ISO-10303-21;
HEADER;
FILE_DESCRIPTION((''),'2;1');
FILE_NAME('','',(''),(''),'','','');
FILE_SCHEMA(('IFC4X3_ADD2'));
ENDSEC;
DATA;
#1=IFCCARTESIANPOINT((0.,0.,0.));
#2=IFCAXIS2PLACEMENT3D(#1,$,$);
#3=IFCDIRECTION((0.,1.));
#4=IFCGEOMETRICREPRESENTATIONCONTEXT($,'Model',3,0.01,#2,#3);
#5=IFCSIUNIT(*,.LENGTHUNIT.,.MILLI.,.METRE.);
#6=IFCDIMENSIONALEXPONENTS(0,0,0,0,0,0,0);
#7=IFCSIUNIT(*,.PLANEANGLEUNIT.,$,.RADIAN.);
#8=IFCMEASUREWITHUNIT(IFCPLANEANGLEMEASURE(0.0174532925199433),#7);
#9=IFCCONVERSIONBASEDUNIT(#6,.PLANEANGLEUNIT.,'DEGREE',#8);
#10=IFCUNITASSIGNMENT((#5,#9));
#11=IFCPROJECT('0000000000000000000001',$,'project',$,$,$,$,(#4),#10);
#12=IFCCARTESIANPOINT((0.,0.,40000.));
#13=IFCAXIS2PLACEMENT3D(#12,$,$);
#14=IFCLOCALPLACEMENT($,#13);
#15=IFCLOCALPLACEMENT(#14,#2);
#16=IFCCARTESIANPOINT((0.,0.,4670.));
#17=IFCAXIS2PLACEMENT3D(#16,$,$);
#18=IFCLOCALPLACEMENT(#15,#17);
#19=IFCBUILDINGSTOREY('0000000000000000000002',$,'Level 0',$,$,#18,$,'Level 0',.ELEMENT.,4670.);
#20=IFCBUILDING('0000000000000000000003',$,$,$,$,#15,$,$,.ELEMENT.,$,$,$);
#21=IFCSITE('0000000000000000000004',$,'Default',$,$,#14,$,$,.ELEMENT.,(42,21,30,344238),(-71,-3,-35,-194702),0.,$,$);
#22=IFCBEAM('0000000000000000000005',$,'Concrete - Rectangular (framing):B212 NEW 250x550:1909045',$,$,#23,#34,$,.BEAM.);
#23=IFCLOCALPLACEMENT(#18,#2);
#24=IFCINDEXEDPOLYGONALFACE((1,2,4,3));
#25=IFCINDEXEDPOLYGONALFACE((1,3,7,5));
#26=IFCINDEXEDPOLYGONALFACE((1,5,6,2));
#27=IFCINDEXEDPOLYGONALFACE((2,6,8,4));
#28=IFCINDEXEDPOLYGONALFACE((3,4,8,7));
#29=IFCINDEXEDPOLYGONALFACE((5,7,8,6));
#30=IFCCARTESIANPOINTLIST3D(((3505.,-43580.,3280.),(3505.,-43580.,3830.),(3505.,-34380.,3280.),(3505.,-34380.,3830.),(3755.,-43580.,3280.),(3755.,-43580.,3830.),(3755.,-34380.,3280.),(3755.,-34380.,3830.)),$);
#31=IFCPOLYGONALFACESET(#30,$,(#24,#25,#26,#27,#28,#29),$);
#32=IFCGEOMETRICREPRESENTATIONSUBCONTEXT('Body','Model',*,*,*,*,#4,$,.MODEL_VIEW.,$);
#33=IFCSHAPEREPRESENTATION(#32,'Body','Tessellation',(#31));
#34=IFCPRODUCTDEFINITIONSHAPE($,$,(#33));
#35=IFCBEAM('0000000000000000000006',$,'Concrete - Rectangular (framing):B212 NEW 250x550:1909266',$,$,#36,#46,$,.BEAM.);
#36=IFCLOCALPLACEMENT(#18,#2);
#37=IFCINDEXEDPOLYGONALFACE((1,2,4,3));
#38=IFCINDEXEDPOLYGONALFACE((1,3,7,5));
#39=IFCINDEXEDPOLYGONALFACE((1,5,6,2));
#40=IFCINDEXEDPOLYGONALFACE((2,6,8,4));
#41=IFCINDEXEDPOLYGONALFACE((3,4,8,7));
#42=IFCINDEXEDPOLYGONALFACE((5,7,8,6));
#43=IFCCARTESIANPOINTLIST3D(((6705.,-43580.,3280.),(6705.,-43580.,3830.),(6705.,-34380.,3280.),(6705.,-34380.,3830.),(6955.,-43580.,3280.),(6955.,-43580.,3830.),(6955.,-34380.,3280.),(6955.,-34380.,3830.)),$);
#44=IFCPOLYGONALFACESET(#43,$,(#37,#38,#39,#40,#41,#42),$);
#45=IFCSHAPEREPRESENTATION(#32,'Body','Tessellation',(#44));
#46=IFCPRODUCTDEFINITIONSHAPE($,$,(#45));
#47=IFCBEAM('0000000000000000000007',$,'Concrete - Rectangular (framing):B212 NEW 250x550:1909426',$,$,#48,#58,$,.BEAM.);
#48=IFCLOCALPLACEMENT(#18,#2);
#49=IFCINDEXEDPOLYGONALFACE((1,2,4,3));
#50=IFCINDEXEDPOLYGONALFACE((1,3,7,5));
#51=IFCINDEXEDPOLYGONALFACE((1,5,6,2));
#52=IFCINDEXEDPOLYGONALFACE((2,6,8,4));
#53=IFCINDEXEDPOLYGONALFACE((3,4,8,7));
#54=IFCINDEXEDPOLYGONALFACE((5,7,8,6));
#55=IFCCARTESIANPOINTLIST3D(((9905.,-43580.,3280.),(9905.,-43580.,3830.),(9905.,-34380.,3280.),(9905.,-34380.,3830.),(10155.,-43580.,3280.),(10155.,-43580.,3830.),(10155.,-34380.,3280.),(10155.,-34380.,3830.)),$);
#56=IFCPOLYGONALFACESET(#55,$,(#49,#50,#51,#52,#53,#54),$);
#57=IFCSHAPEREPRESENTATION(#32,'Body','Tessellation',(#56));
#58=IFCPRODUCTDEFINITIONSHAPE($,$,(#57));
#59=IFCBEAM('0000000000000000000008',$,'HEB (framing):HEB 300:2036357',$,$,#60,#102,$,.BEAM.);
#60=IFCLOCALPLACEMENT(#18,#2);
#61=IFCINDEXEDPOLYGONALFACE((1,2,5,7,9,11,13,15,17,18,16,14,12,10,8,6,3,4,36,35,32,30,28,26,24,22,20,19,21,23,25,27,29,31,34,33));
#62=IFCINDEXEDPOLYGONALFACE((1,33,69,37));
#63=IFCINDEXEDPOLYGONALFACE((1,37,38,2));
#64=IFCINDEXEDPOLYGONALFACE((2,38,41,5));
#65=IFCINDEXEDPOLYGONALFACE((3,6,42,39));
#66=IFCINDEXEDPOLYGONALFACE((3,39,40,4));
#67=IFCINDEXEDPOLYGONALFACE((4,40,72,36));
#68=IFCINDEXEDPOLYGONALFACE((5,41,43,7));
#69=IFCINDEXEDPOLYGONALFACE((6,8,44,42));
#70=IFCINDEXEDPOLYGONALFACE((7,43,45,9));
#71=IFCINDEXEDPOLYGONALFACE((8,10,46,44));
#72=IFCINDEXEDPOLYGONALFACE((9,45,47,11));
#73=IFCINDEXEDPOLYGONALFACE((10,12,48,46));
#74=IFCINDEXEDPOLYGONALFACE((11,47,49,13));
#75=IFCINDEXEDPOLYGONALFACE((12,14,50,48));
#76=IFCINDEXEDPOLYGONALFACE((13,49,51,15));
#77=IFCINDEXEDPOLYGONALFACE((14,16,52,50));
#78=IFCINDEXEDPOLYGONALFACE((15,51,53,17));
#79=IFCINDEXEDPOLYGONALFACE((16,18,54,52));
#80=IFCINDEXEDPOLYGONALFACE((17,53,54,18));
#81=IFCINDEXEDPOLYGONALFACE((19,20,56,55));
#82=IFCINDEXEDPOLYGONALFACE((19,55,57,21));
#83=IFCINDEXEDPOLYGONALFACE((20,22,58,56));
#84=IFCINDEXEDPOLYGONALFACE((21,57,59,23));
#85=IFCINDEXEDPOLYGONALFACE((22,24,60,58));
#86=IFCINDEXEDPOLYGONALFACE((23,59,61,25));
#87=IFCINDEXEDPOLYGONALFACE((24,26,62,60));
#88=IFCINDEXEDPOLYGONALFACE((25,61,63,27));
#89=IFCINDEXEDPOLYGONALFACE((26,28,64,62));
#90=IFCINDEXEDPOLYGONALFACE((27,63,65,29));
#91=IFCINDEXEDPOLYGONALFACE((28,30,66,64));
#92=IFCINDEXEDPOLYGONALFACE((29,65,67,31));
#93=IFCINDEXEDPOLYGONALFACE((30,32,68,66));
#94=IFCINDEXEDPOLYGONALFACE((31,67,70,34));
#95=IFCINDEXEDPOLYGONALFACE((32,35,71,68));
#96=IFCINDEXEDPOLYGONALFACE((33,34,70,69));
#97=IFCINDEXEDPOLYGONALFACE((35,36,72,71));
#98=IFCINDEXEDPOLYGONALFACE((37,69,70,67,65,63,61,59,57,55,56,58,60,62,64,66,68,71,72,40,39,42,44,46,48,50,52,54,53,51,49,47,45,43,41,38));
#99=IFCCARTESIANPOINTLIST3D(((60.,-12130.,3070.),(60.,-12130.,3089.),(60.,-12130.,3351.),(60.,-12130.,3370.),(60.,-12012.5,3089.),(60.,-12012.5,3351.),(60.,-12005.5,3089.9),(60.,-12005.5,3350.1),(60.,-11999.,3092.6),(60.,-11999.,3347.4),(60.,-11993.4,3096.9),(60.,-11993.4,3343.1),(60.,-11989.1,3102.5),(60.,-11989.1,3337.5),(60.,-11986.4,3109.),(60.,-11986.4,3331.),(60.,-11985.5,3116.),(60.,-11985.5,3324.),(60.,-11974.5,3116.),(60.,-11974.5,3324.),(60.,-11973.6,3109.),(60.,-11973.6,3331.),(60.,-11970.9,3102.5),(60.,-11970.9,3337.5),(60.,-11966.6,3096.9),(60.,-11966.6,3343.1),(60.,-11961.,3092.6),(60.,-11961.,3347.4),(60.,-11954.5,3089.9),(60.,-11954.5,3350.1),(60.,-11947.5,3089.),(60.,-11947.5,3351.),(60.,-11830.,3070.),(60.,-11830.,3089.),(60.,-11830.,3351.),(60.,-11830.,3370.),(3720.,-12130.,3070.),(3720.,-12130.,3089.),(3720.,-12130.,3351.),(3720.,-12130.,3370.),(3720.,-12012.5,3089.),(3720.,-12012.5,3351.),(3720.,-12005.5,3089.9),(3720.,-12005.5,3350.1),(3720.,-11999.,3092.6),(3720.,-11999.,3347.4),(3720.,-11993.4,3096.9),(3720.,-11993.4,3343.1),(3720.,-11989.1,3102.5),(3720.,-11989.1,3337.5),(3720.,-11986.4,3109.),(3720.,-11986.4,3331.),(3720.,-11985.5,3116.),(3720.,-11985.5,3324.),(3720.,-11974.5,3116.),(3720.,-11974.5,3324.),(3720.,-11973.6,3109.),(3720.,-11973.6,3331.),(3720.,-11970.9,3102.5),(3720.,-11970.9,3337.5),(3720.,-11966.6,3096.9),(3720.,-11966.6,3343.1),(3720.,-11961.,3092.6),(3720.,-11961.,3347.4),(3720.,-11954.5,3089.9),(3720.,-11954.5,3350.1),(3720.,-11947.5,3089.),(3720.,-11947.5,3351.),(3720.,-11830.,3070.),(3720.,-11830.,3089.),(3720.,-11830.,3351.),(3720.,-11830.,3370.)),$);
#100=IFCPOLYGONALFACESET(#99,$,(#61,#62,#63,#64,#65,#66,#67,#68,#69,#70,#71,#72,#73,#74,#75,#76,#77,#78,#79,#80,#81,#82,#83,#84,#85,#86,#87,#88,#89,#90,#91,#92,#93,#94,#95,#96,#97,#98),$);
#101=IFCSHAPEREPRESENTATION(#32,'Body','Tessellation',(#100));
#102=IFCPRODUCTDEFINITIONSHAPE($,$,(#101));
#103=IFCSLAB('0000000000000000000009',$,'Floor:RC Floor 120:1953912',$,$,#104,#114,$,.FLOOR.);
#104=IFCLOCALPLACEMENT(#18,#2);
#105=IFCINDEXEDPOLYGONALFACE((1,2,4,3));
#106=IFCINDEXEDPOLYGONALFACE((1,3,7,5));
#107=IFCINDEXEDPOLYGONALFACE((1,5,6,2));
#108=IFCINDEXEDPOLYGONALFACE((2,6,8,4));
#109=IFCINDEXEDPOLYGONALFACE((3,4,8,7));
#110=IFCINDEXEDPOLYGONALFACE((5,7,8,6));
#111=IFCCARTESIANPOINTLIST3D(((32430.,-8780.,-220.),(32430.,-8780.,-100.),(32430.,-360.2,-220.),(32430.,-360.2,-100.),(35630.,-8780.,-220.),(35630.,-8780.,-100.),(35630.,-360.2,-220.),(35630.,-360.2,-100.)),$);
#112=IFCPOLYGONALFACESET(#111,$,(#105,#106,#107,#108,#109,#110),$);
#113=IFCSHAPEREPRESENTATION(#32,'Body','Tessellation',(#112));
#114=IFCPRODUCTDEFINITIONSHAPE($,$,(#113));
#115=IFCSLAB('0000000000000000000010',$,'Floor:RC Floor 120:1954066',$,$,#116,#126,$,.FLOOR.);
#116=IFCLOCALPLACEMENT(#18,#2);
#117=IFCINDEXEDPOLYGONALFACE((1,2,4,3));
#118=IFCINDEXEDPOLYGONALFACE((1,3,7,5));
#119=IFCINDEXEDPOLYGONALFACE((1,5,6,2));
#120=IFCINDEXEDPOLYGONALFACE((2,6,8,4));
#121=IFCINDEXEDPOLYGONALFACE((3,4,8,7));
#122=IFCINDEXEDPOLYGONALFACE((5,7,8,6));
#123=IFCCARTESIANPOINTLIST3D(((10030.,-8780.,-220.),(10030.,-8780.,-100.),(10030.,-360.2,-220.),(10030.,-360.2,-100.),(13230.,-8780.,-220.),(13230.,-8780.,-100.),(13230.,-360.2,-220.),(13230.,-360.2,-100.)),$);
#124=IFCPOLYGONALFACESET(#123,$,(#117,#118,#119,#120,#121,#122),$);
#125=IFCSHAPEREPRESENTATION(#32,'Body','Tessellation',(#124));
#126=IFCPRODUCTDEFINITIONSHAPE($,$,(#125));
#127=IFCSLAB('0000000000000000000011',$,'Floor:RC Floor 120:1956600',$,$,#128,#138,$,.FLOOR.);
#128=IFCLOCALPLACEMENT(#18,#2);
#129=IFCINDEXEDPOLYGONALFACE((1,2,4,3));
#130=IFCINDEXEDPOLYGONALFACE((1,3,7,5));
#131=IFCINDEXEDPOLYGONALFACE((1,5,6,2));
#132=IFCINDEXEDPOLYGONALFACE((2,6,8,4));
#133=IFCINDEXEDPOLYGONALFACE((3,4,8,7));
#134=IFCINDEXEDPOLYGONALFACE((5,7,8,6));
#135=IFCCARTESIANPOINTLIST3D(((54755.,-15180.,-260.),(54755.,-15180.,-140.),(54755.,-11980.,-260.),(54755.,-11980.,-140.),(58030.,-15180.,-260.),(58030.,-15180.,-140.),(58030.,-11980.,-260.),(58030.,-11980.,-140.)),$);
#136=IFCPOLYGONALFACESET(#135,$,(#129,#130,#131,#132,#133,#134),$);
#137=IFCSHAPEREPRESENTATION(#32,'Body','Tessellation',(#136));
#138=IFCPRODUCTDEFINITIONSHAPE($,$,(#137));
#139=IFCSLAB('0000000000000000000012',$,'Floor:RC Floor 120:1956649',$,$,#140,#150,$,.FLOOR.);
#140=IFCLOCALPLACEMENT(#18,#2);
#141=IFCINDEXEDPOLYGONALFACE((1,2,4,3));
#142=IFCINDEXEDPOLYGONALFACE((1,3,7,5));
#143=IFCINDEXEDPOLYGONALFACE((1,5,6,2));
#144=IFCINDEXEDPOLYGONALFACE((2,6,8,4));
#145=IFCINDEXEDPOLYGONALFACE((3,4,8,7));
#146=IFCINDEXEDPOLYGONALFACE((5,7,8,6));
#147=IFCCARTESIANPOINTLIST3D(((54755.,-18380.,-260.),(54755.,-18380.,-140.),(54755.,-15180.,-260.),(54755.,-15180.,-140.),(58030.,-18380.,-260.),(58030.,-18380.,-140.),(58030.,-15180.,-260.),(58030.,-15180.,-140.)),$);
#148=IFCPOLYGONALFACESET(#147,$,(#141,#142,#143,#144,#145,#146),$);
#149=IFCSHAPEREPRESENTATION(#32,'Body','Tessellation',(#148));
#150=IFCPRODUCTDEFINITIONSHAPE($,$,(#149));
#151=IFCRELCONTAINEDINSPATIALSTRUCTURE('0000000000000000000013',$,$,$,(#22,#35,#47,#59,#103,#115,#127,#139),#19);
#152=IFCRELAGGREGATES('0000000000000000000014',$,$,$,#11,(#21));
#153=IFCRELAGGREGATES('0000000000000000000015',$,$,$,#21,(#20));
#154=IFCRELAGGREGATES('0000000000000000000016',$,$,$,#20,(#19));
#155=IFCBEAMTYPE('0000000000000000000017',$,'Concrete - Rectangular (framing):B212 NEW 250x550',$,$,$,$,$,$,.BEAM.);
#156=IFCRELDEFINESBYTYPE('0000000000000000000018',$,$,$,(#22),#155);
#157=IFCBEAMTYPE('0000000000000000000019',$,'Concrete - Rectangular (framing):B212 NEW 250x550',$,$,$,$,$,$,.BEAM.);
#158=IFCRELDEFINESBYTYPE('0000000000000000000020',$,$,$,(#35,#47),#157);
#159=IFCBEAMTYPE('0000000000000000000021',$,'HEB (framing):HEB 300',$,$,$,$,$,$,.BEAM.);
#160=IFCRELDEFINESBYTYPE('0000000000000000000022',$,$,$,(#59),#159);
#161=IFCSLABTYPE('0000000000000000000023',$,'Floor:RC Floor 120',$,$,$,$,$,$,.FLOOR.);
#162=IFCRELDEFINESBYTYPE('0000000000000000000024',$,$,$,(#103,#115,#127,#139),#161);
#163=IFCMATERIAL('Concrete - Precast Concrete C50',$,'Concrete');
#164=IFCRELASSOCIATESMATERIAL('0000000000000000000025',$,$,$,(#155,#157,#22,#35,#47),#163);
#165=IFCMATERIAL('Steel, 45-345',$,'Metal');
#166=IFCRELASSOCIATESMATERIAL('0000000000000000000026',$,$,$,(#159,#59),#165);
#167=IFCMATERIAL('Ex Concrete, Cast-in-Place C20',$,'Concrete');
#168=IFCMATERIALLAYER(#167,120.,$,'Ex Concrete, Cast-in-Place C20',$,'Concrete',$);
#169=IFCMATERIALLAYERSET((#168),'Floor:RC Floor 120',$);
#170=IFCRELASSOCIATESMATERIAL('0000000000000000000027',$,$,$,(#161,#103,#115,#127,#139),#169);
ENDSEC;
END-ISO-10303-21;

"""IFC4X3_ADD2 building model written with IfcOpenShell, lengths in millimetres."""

from ifc_helpers import new_model, entity, si_unit, converted_unit, direction, frame, frame_2d, origin, origin_2d_with_axis, place, context, subcontext, project, spatial, polyline, circle_curve, parameter, trimmed, segment, composite_curve, rectangle, outline, extrude, source, transform, mapped, material, layer, layer_set, layer_usage, material_profile, profile_set, profile_usage, type_object, type_shapes, element, save


model = new_model("IFC4X3_ADD2")

# Units and contexts
model_context = context("Model", 3, precision=0.01, world=origin(), true_north=direction((0.0, 1.0)))
body_context = subcontext(model_context, "Body", "Model", "MODEL_VIEW")
ifc_project = project(units=[si_unit("LENGTHUNIT", "METRE", prefix="MILLI"), converted_unit("PLANEANGLEUNIT", "DEGREE", entity("IfcPlaneAngleMeasure", 0.0174532925199433), si_unit("PLANEANGLEUNIT", "RADIAN"), dimensions=[0, 0, 0, 0, 0, 0, 0])], contexts=[model_context])

# Site, building, storey
site_placement = place(None, frame((0.0, 0.0, 40000.0)))
site = spatial("IfcSite", under=ifc_project, at=site_placement, Name="Default", CompositionType="ELEMENT", RefLatitude=(42, 21, 30, 344238), RefLongitude=(-71, -3, -35, -194702), RefElevation=0.0)
building_placement = place(site_placement, origin())
building = spatial("IfcBuilding", under=site, at=building_placement, CompositionType="ELEMENT")
storey_placement = place(building_placement, frame((0.0, 0.0, 4670.0)))
storey = spatial("IfcBuildingStorey", under=building, at=storey_placement, Name="Level 0", LongName="Level 0", CompositionType="ELEMENT", Elevation=4670.0)

# Shared definitions
ifc_material_1 = material(Name="Steel, 45-345", Category="Metal")

# Beams
ifc_material_2 = material(Name="Concrete - Precast Concrete C50", Category="Concrete")
ifc_material_profile_1 = material_profile(ifc_material_2, rectangle(XDim=9200.0, YDim=250.0, at=origin_2d_with_axis()), Name="B212 NEW 250x550")
ifc_profile_set_1 = profile_set([ifc_material_profile_1], Name="B212 NEW 250x550")
ifc_profile_usage_1 = profile_usage(ifc_profile_set_1, cardinal=8)
beam_type_1 = type_object("IfcBeamType", Name="Concrete - Rectangular (framing):B212 NEW 250x550", PredefinedType="BEAM", material=ifc_profile_set_1)
shared_shape_1 = source(origin(), body_context, "Body", "SweptSolid", [
    extrude(rectangle(XDim=9200.0, YDim=250.0, at=origin_2d_with_axis()), frame((0.0, 0.0, -275.0), z_axis=(0.0, 0.0, 1.0), x_axis=(-1.0, 0.0, 0.0)), (0.0, 0.0, 1.0), 550.0),
])
type_shapes(beam_type_1, [shared_shape_1])
beam_1_placement = place(storey_placement, frame((3630.0, -38980.0, 3555.0), z_axis=(0.0, 0.0, 1.0), x_axis=(0.0, 1.0, 0.0)))
element("IfcBeam", 1, at=beam_1_placement, inside=storey, type_object=beam_type_1, material=ifc_profile_usage_1, Name="Concrete - Rectangular (framing):B212 NEW 250x550:1909045", PredefinedType="BEAM", context=body_context, shape_type="MappedRepresentation", body=[
    mapped(shared_shape_1, transform((0.0, 0.0, 0.0), scale=1.0)),
])
beam_type_2 = type_object("IfcBeamType", Name="Concrete - Rectangular (framing):B212 NEW 250x550", PredefinedType="BEAM", material=ifc_profile_set_1)
shared_shape_2 = source(origin(), body_context, "Body", "SweptSolid", [
    extrude(rectangle(XDim=9200.0, YDim=250.0, at=origin_2d_with_axis()), frame((0.0, 0.0, -275.0), z_axis=(0.0, 0.0, 1.0), x_axis=(-1.0, 0.0, 0.0)), (0.0, 0.0, 1.0), 550.0),
])
type_shapes(beam_type_2, [shared_shape_2])
for number, where, z_axis, x_axis, name in (
    (2, (6830.0, -38980.0, 3555.0), (0.0, 0.0, 1.0), (0.0, 1.0, 0.0), "Concrete - Rectangular (framing):B212 NEW 250x550:1909266"),
    (3, (10030.0, -38980.0, 3555.0), (0.0, 0.0, 1.0), (0.0, 1.0, 0.0), "Concrete - Rectangular (framing):B212 NEW 250x550:1909426"),
):
    element("IfcBeam", number, at=place(storey_placement, frame(where, z_axis=z_axis, x_axis=x_axis)), inside=storey, type_object=beam_type_2, material=ifc_profile_usage_1, Name=name, PredefinedType="BEAM", context=body_context, shape_type="MappedRepresentation", body=[
        mapped(shared_shape_2, transform((0.0, 0.0, 0.0), scale=1.0)),
    ])
ifc_material_profile_2 = material_profile(ifc_material_1, outline(composite_curve([segment(polyline([(-150.0, -131.0), (-150.0, -150.0)]), True, "CONTINUOUS"), segment(polyline([(-150.0, -150.0), (150.0, -150.0)]), True, "CONTINUOUS"), segment(polyline([(150.0, -150.0), (150.0, -131.0)]), True, "CONTINUOUS"), segment(polyline([(150.0, -131.0), (32.5, -131.0)]), True, "CONTINUOUS"), segment(trimmed(circle_curve(frame_2d((32.5, -104.0), x_axis=(1.0, 0.0)), 27.0), [parameter(180.0)], [parameter(270.0)], True, "PARAMETER"), False, "CONTINUOUS"), segment(polyline([(5.5, -104.0), (5.5, 104.0)]), True, "CONTINUOUS"), segment(trimmed(circle_curve(frame_2d((32.5, 104.0), x_axis=(1.0, 0.0)), 27.0), [parameter(90.0)], [parameter(180.0)], True, "PARAMETER"), False, "CONTINUOUS"), segment(polyline([(32.5, 131.0), (150.0, 131.0)]), True, "CONTINUOUS"), segment(polyline([(150.0, 131.0), (150.0, 150.0)]), True, "CONTINUOUS"), segment(polyline([(150.0, 150.0), (-150.0, 150.0)]), True, "CONTINUOUS"), segment(polyline([(-150.0, 150.0), (-150.0, 131.0)]), True, "CONTINUOUS"), segment(polyline([(-150.0, 131.0), (-32.5, 131.0)]), True, "CONTINUOUS"), segment(trimmed(circle_curve(frame_2d((-32.5, 104.0), x_axis=(1.0, 0.0)), 27.0), [parameter(360.0)], [parameter(90.0)], True, "PARAMETER"), False, "CONTINUOUS"), segment(polyline([(-5.5, 104.0), (-5.5, -104.0)]), True, "CONTINUOUS"), segment(trimmed(circle_curve(frame_2d((-32.5, -104.0), x_axis=(1.0, 0.0)), 27.0), [parameter(270.0)], [parameter(0.0)], True, "PARAMETER"), False, "CONTINUOUS"), segment(polyline([(-32.5, -131.0), (-150.0, -131.0)]), True, "CONTINUOUS")], self_intersect=False)), Name="HEB 300")
ifc_profile_set_2 = profile_set([ifc_material_profile_2], Name="HEB 300")
ifc_profile_usage_2 = profile_usage(ifc_profile_set_2, cardinal=8)
beam_type_3 = type_object("IfcBeamType", Name="HEB (framing):HEB 300", PredefinedType="BEAM", material=ifc_profile_set_2)
shared_shape_3 = source(origin(), body_context, "Body", "SweptSolid", [
    extrude(outline(composite_curve([segment(polyline([(-150.0, -131.0), (-150.0, -150.0)]), True, "CONTINUOUS"), segment(polyline([(-150.0, -150.0), (150.0, -150.0)]), True, "CONTINUOUS"), segment(polyline([(150.0, -150.0), (150.0, -131.0)]), True, "CONTINUOUS"), segment(polyline([(150.0, -131.0), (32.5, -131.0)]), True, "CONTINUOUS"), segment(trimmed(circle_curve(frame_2d((32.5, -104.0), x_axis=(1.0, 0.0)), 27.0), [parameter(180.0)], [parameter(270.0)], True, "PARAMETER"), False, "CONTINUOUS"), segment(polyline([(5.5, -104.0), (5.5, 104.0)]), True, "CONTINUOUS"), segment(trimmed(circle_curve(frame_2d((32.5, 104.0), x_axis=(1.0, 0.0)), 27.0), [parameter(90.0)], [parameter(180.0)], True, "PARAMETER"), False, "CONTINUOUS"), segment(polyline([(32.5, 131.0), (150.0, 131.0)]), True, "CONTINUOUS"), segment(polyline([(150.0, 131.0), (150.0, 150.0)]), True, "CONTINUOUS"), segment(polyline([(150.0, 150.0), (-150.0, 150.0)]), True, "CONTINUOUS"), segment(polyline([(-150.0, 150.0), (-150.0, 131.0)]), True, "CONTINUOUS"), segment(polyline([(-150.0, 131.0), (-32.5, 131.0)]), True, "CONTINUOUS"), segment(trimmed(circle_curve(frame_2d((-32.5, 104.0), x_axis=(1.0, 0.0)), 27.0), [parameter(360.0)], [parameter(90.0)], True, "PARAMETER"), False, "CONTINUOUS"), segment(polyline([(-5.5, 104.0), (-5.5, -104.0)]), True, "CONTINUOUS"), segment(trimmed(circle_curve(frame_2d((-32.5, -104.0), x_axis=(1.0, 0.0)), 27.0), [parameter(270.0)], [parameter(0.0)], True, "PARAMETER"), False, "CONTINUOUS"), segment(polyline([(-32.5, -131.0), (-150.0, -131.0)]), True, "CONTINUOUS")], self_intersect=False)), frame((-1785.0, 0.0, 0.0), z_axis=(-1.0, 0.0, 0.0), x_axis=(0.0, -1.0, 0.0)), (0.0, 0.0, -1.0), 3660.0),
])
type_shapes(beam_type_3, [shared_shape_3])
beam_2_placement = place(storey_placement, frame((1935.0, -11980.0, 3220.0), z_axis=(0.0, 0.0, 1.0), x_axis=(-1.0, 0.0, 0.0)))
element("IfcBeam", 4, at=beam_2_placement, inside=storey, type_object=beam_type_3, material=ifc_profile_usage_2, Name="HEB (framing):HEB 300:2036357", PredefinedType="BEAM", context=body_context, shape_type="MappedRepresentation", body=[
    mapped(shared_shape_3, transform((0.0, 0.0, 0.0), scale=1.0)),
])

# Slabs
ifc_material_3 = material(Name="Ex Concrete, Cast-in-Place C20", Category="Concrete")
ifc_layer_1 = layer(ifc_material_3, 120.0, Name="Ex Concrete, Cast-in-Place C20", Category="Concrete")
ifc_layer_set_1 = layer_set([ifc_layer_1], Name="Floor:RC Floor 120")
ifc_layer_usage_1 = layer_usage(ifc_layer_set_1, "AXIS3", "POSITIVE", 0.0)
slab_type_1 = type_object("IfcSlabType", Name="Floor:RC Floor 120", PredefinedType="FLOOR", material=ifc_layer_set_1)
slab_1_placement = place(storey_placement, origin())
element("IfcSlab", 5, at=slab_1_placement, inside=storey, type_object=slab_type_1, material=ifc_layer_usage_1, Name="Floor:RC Floor 120:1953912", PredefinedType="FLOOR", context=body_context, shape_type="SweptSolid", body=[
    extrude(rectangle(XDim=8419.8, YDim=3200.0, at=frame_2d((0.0, 0.0), x_axis=(1.0, 0.0))), frame((34030.0, -4570.1, -100.0), z_axis=(0.0, 0.0, -1.0), x_axis=(0.0, 1.0, 0.0)), (0.0, 0.0, 1.0), 120.0),
])
ifc_layer_usage_2 = layer_usage(ifc_layer_set_1, "AXIS3", "POSITIVE", 0.0)
slab_2_placement = place(storey_placement, origin())
element("IfcSlab", 6, at=slab_2_placement, inside=storey, type_object=slab_type_1, material=ifc_layer_usage_2, Name="Floor:RC Floor 120:1954066", PredefinedType="FLOOR", context=body_context, shape_type="SweptSolid", body=[
    extrude(rectangle(XDim=8419.8, YDim=3200.0, at=origin_2d_with_axis()), frame((11630.0, -4570.1, -100.0), z_axis=(0.0, 0.0, -1.0), x_axis=(0.0, 1.0, 0.0)), (0.0, 0.0, 1.0), 120.0),
])
ifc_layer_usage_3 = layer_usage(ifc_layer_set_1, "AXIS3", "POSITIVE", 0.0)
slab_3_placement = place(storey_placement, origin())
element("IfcSlab", 7, at=slab_3_placement, inside=storey, type_object=slab_type_1, material=ifc_layer_usage_3, Name="Floor:RC Floor 120:1956600", PredefinedType="FLOOR", context=body_context, shape_type="SweptSolid", body=[
    extrude(rectangle(XDim=3200.0, YDim=3275.0, at=frame_2d((0.0, 0.0), x_axis=(1.0, 0.0))), frame((56392.5, -13580.0, -140.0), z_axis=(0.0, 0.0, -1.0), x_axis=(0.0, 1.0, 0.0)), (0.0, 0.0, 1.0), 120.0),
])
ifc_layer_usage_4 = layer_usage(ifc_layer_set_1, "AXIS3", "POSITIVE", 0.0)
slab_4_placement = place(storey_placement, origin())
element("IfcSlab", 8, at=slab_4_placement, inside=storey, type_object=slab_type_1, material=ifc_layer_usage_4, Name="Floor:RC Floor 120:1956649", PredefinedType="FLOOR", context=body_context, shape_type="SweptSolid", body=[
    extrude(rectangle(XDim=3200.0, YDim=3275.0, at=frame_2d((0.0, 0.0), x_axis=(1.0, 0.0))), frame((56392.5, -16780.0, -140.0), z_axis=(0.0, 0.0, -1.0), x_axis=(0.0, 1.0, 0.0)), (0.0, 0.0, 1.0), 120.0),
])

save(model, "model.ifc")
